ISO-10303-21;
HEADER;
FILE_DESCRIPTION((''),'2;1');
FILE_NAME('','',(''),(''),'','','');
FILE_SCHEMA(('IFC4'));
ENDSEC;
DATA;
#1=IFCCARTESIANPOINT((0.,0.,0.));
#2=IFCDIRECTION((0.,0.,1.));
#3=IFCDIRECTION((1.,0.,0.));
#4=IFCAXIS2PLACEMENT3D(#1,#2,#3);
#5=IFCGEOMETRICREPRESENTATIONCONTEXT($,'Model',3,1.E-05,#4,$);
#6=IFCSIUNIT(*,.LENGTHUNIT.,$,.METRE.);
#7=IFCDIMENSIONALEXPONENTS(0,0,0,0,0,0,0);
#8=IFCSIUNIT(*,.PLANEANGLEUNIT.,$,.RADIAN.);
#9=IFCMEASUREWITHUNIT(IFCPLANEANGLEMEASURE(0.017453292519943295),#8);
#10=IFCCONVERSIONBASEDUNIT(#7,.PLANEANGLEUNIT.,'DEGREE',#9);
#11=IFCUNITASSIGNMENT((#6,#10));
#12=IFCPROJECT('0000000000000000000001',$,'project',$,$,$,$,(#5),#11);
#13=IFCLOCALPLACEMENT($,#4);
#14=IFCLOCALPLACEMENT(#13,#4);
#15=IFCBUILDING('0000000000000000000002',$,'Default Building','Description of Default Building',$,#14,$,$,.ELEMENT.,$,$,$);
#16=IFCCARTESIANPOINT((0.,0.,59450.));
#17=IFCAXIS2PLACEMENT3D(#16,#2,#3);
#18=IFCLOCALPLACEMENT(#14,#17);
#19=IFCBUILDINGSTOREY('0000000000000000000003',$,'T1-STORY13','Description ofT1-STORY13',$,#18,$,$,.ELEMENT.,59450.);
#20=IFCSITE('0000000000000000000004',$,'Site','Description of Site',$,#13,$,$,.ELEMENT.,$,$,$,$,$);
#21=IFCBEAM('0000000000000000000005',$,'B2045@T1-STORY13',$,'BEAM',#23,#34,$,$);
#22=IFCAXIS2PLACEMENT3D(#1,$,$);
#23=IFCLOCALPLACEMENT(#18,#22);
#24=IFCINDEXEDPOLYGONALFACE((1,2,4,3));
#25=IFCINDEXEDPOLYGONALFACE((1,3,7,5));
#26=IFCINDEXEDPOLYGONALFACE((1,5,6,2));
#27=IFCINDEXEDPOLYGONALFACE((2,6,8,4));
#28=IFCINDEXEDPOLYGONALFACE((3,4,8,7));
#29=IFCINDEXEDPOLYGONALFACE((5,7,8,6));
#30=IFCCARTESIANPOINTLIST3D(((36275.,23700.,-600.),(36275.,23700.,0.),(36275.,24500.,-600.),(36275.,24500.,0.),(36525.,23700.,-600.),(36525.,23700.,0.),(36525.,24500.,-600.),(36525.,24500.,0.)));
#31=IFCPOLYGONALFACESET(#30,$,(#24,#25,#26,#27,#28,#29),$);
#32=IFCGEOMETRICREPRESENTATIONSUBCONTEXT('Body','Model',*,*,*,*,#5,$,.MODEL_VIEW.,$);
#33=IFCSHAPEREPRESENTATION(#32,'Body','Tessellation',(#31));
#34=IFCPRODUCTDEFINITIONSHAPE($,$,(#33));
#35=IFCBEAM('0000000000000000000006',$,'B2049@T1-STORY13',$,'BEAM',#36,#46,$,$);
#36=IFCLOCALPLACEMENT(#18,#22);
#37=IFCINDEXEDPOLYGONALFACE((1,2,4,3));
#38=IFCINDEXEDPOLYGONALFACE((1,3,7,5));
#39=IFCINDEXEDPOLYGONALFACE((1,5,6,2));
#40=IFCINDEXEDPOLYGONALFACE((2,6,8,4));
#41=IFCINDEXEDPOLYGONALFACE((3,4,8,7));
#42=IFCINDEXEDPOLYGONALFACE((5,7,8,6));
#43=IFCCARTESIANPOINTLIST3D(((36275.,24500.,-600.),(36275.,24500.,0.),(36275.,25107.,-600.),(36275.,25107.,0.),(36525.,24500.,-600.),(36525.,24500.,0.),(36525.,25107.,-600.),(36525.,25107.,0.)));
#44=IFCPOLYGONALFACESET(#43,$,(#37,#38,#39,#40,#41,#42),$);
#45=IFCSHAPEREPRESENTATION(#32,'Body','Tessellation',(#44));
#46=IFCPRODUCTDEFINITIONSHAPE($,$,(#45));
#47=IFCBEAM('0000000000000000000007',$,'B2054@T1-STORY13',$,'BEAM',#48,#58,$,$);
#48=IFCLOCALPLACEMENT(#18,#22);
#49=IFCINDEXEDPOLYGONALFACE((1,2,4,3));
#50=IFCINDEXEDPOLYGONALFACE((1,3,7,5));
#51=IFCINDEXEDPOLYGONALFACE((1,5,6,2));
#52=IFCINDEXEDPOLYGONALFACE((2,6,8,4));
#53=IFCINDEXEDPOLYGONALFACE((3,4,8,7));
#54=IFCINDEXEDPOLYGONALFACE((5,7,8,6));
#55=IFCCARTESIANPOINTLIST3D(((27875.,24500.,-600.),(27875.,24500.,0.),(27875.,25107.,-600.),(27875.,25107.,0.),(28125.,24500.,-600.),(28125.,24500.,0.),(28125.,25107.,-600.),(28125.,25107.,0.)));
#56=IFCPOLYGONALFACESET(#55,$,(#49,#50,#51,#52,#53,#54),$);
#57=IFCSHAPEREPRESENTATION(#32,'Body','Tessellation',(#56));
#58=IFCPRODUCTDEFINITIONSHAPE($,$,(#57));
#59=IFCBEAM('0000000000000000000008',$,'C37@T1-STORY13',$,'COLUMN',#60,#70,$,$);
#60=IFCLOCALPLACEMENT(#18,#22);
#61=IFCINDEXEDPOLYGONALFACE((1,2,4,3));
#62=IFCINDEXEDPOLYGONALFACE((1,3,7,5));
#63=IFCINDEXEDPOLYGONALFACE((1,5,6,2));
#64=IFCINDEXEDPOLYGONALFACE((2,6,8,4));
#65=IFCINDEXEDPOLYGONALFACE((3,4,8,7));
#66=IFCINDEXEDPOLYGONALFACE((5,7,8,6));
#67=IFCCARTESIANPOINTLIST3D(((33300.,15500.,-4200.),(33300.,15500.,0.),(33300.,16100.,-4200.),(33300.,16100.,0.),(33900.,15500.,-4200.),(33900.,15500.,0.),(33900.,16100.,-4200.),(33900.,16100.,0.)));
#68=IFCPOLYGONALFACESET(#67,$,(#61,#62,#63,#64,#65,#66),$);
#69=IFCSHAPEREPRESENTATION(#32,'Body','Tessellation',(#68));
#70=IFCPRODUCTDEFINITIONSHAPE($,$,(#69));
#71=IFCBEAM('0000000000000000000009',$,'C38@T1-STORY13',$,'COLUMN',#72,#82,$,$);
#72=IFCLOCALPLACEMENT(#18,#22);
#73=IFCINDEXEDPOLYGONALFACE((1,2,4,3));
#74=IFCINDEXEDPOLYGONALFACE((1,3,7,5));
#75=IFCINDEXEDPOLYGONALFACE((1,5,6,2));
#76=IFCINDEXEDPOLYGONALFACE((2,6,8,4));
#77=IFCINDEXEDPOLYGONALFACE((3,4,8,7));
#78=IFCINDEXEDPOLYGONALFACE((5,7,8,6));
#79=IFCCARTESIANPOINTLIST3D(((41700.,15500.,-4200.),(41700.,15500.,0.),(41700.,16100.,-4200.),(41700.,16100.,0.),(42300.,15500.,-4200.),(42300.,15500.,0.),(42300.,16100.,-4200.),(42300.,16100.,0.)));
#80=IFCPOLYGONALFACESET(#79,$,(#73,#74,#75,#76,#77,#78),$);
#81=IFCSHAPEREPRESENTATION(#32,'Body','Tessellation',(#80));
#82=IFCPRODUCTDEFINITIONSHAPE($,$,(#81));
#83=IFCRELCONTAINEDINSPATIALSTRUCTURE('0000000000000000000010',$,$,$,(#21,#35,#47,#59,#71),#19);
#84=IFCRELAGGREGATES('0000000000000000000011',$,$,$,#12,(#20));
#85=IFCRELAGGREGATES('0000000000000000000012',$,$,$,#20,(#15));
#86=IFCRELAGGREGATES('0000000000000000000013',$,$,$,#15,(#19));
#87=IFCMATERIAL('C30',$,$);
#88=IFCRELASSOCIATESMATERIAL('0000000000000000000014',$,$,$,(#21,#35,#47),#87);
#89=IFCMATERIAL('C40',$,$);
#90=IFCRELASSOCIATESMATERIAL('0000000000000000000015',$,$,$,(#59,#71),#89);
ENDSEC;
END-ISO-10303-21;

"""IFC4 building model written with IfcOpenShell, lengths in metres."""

from ifc_helpers import new_model, entity, si_unit, converted_unit, frame, origin_with_axes, place, context, subcontext, project, spatial, rectangle, extrude, material, element, save


model = new_model("IFC4")

# Units and contexts
model_context = context("Model", 3, precision=1e-05, world=origin_with_axes())
body_context = subcontext(model_context, "Body", "Model", "MODEL_VIEW")
ifc_project = project(units=[si_unit("LENGTHUNIT", "METRE"), converted_unit("PLANEANGLEUNIT", "DEGREE", entity("IfcPlaneAngleMeasure", 0.017453292519943295), si_unit("PLANEANGLEUNIT", "RADIAN"), dimensions=[0, 0, 0, 0, 0, 0, 0])], contexts=[model_context])

# Site, building, storey
site_placement = place(None, origin_with_axes())
site = spatial("IfcSite", under=ifc_project, at=site_placement, Name="Site", Description="Description of Site", CompositionType="ELEMENT")
building_placement = place(site_placement, origin_with_axes())
building = spatial("IfcBuilding", under=site, at=building_placement, Name="Default Building", Description="Description of Default Building", CompositionType="ELEMENT")
storey_placement = place(building_placement, frame((0.0, 0.0, 59450.0), z_axis=(0.0, 0.0, 1.0), x_axis=(1.0, 0.0, 0.0)))
storey = spatial("IfcBuildingStorey", under=building, at=storey_placement, Name="T1-STORY13", Description="Description ofT1-STORY13", CompositionType="ELEMENT", Elevation=59450.0)

# Beams
ifc_material_1 = material(Name="C30")
beam_1_placement = place(storey_placement, frame((36400.0, 23700.0, -300.0), z_axis=(0.0, 1.0, 0.0), x_axis=(-1.0, 0.0, 0.0)))
element("IfcBeam", 1, at=beam_1_placement, inside=storey, material=ifc_material_1, Name="B2045@T1-STORY13", ObjectType="BEAM", context=body_context, shape_type="SweptSolid", body=[
    extrude(rectangle(XDim=250.0, YDim=600.0), origin_with_axes(), (0.0, 0.0, 1.0), 800.0),
])
for number, where, z_axis, x_axis, name in (
    (2, (36400.0, 24500.0, -300.0), (0.0, 1.0, 0.0), (-1.0, 0.0, 0.0), "B2049@T1-STORY13"),
    (3, (28000.0, 24500.0, -300.0), (0.0, 1.0, 0.0), (-1.0, 0.0, 0.0), "B2054@T1-STORY13"),
):
    element("IfcBeam", number, at=place(storey_placement, frame(where, z_axis=z_axis, x_axis=x_axis)), inside=storey, material=ifc_material_1, Name=name, ObjectType="BEAM", context=body_context, shape_type="SweptSolid", body=[
        extrude(rectangle(XDim=250.0, YDim=600.0), origin_with_axes(), (0.0, 0.0, 1.0), 607.0),
    ])
ifc_material_2 = material(Name="C40")
for number, where, z_axis, x_axis, name in (
    (4, (33600.0, 15800.0, -4200.0), (0.0, 0.0, 1.0), (-1.0, 0.0, 0.0), "C37@T1-STORY13"),
    (5, (42000.0, 15800.0, -4200.0), (0.0, 0.0, 1.0), (-1.0, 0.0, 0.0), "C38@T1-STORY13"),
):
    element("IfcBeam", number, at=place(storey_placement, frame(where, z_axis=z_axis, x_axis=x_axis)), inside=storey, material=ifc_material_2, Name=name, ObjectType="COLUMN", context=body_context, shape_type="SweptSolid", body=[
        extrude(rectangle(XDim=600.0, YDim=600.0), origin_with_axes(), (0.0, 0.0, 1.0), 4200.0),
    ])

save(model, "model.ifc")
